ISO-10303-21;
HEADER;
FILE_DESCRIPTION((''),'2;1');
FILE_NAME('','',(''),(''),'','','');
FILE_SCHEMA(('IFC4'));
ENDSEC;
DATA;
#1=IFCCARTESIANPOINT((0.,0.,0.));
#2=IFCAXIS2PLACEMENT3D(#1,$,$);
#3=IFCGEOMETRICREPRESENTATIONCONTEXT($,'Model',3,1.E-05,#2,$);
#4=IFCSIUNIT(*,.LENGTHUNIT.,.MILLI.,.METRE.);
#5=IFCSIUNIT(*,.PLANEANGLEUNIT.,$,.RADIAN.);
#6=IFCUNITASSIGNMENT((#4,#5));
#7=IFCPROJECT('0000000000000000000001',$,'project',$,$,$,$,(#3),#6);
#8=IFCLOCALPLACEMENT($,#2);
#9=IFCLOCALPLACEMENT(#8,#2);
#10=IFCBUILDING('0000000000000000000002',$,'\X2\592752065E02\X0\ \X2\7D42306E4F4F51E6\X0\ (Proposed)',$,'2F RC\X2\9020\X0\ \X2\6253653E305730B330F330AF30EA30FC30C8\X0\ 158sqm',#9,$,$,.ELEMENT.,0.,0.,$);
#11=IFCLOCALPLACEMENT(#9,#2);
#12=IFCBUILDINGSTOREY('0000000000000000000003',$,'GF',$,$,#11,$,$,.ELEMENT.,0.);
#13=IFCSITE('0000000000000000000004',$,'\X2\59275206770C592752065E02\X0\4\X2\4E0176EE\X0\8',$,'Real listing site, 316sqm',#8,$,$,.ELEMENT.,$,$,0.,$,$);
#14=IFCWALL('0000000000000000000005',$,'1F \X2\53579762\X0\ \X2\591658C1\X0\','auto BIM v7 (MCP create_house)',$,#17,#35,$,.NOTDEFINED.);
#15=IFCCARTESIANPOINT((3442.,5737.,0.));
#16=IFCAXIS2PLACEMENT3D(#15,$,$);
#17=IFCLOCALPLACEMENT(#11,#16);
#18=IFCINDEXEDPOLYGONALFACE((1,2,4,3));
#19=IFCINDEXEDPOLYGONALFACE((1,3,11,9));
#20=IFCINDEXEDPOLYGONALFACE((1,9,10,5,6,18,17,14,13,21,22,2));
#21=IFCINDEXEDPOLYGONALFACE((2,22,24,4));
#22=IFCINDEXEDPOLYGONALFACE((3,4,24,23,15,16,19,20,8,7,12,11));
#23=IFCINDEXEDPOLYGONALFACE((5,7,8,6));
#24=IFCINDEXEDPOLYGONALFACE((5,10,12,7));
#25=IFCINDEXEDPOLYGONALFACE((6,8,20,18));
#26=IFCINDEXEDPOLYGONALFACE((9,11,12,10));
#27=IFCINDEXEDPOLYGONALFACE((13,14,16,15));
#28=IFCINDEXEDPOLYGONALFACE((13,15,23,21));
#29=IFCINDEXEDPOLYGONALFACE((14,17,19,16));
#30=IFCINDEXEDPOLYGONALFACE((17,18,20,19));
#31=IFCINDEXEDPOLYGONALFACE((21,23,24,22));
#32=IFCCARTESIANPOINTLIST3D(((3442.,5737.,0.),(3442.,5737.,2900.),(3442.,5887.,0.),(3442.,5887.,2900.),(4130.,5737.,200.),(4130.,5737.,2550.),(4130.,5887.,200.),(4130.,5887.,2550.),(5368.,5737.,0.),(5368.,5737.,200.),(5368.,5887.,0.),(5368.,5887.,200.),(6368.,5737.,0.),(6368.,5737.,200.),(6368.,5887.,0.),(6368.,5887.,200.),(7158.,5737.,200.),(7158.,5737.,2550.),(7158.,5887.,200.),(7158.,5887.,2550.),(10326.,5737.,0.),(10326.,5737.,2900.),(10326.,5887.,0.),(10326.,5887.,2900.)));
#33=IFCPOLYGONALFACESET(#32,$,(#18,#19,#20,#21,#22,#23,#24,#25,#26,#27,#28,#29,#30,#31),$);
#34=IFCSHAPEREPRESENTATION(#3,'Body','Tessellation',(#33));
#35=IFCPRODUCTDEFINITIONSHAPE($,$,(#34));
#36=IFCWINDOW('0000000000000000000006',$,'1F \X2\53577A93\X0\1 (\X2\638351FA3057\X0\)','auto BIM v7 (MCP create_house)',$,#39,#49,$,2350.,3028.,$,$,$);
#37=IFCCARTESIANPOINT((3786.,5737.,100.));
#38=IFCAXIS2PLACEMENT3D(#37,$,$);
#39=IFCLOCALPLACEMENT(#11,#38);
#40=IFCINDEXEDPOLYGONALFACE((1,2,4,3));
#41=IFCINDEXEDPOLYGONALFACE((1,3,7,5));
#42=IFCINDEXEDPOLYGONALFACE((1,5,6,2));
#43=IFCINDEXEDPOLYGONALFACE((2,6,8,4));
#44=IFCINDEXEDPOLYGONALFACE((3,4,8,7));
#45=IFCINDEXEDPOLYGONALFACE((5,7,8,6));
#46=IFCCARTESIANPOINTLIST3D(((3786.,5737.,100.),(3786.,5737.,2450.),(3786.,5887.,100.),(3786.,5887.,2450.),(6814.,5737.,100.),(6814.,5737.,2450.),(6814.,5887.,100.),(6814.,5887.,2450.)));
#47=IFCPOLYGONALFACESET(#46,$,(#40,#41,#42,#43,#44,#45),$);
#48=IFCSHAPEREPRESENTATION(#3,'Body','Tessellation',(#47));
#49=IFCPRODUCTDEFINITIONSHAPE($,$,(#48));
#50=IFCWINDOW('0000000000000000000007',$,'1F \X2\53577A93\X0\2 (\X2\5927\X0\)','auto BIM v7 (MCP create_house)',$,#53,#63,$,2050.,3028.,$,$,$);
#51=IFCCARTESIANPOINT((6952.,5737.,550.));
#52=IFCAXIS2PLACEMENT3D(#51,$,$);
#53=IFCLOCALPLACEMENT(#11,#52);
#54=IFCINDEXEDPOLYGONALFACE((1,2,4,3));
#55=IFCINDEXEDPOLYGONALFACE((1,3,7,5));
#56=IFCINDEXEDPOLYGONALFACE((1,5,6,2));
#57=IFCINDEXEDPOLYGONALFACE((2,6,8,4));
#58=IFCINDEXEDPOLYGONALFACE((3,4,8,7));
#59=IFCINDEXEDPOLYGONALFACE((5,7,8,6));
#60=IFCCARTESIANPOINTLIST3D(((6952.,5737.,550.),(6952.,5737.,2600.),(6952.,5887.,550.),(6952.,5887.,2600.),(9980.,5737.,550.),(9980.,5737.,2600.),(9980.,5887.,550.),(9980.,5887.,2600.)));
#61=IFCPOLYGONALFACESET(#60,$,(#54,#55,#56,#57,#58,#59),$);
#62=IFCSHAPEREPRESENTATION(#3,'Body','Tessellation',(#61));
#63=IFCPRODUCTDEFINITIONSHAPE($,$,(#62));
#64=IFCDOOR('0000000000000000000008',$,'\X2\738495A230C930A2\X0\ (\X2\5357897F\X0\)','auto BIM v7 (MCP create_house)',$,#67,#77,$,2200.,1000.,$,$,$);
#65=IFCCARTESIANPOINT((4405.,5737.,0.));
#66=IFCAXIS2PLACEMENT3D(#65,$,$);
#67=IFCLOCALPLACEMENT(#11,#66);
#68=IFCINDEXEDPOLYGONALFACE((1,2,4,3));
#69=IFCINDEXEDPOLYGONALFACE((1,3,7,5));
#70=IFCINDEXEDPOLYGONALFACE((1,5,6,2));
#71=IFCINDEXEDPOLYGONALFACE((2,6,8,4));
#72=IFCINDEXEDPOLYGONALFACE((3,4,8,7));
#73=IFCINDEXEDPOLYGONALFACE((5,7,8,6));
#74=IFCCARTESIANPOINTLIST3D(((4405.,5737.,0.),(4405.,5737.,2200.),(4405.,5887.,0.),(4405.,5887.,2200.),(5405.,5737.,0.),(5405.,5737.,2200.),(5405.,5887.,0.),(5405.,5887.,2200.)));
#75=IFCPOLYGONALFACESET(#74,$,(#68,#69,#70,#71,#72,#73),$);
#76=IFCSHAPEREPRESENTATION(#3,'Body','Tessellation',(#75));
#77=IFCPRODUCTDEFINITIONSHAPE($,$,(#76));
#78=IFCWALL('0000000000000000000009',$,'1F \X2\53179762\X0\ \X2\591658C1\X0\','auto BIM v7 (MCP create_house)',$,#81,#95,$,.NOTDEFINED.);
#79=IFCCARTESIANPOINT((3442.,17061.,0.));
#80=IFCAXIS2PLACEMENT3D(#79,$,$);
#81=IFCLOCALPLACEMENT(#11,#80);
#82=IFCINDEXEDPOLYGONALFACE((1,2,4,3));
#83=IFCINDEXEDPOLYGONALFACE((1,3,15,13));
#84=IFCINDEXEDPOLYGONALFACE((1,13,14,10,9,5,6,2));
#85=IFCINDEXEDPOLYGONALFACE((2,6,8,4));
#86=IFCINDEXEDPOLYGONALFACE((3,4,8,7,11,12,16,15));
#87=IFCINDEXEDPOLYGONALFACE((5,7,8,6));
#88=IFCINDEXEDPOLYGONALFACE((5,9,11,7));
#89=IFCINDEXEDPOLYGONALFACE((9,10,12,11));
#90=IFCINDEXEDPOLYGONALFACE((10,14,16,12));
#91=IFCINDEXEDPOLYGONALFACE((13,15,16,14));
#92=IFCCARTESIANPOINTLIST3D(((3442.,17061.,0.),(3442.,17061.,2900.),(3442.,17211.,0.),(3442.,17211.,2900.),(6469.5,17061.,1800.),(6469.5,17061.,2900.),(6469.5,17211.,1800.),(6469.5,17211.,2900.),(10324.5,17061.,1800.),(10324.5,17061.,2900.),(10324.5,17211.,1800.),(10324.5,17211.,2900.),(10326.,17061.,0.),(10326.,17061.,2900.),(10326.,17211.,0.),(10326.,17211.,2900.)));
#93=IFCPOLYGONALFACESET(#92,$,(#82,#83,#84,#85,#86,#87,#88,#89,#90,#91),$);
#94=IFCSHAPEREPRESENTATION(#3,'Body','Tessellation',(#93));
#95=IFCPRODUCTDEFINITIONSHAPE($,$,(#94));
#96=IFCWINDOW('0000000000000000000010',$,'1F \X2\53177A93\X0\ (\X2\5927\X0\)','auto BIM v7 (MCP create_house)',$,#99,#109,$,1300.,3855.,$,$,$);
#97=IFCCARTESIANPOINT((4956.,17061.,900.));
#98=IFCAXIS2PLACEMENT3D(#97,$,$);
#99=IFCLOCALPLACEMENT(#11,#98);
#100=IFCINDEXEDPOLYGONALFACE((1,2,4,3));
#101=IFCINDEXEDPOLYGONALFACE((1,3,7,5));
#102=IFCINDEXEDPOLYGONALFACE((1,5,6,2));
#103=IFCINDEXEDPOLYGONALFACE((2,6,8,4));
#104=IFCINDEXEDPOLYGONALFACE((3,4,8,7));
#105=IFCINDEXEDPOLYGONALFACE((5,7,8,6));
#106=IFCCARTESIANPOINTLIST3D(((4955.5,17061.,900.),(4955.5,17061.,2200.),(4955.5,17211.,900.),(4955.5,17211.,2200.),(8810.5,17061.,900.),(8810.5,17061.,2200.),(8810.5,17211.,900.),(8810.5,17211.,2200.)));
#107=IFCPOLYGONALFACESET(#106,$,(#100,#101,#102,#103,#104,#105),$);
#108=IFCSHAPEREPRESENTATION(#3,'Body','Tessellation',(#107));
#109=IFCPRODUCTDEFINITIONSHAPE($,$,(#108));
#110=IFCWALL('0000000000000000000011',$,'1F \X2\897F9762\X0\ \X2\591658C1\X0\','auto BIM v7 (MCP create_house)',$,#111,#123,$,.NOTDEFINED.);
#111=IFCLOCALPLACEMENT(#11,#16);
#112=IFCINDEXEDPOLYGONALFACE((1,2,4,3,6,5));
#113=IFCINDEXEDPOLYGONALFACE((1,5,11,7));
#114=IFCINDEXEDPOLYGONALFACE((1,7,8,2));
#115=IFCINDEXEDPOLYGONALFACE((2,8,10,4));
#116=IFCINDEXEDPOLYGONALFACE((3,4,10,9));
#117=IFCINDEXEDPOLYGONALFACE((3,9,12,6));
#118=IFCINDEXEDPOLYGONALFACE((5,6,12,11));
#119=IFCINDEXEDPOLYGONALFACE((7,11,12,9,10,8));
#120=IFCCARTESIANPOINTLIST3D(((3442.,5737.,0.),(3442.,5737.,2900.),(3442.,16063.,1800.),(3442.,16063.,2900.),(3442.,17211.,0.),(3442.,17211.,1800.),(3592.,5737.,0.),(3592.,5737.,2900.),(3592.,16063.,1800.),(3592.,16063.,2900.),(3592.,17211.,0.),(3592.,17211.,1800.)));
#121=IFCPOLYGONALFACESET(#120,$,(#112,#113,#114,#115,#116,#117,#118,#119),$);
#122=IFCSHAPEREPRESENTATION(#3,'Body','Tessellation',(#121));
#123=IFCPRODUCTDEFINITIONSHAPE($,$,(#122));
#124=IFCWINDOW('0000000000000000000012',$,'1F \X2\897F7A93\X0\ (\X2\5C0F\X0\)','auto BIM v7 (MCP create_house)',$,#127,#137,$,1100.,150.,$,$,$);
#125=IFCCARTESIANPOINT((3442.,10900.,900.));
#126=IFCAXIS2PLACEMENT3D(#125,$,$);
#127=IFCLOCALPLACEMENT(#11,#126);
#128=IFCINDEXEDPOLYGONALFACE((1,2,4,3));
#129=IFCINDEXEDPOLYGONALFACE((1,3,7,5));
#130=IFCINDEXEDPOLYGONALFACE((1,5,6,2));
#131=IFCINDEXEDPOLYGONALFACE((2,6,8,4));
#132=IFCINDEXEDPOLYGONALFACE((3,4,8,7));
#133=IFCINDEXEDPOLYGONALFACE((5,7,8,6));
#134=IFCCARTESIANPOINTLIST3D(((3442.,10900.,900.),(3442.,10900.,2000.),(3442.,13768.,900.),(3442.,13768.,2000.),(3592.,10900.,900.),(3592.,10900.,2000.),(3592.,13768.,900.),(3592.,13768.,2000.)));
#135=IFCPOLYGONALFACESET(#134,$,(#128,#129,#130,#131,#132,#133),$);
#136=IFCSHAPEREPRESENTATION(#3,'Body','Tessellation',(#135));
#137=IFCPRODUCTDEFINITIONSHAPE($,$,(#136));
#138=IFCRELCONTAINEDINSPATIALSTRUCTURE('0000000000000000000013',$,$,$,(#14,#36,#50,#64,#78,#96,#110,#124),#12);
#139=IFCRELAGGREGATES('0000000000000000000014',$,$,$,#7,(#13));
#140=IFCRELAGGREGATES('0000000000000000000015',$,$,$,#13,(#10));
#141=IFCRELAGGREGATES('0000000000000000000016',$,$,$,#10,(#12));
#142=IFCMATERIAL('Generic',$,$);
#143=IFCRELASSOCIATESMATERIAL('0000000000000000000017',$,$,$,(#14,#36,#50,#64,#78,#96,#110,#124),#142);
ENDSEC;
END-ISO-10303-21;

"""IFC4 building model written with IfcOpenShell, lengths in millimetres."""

from ifc_helpers import new_model, si_unit, frame, frame_2d, origin, place, context, project, spatial, rectangle, extrude, material, element, fill, save


model = new_model("IFC4")

# Units and contexts
model_context = context("Model", 3, precision=1e-05, world=origin())
ifc_project = project(units=[si_unit("LENGTHUNIT", "METRE", prefix="MILLI"), si_unit("PLANEANGLEUNIT", "RADIAN")], contexts=[model_context])

# Site, building, storey
site_placement = place(None, origin())
site = spatial("IfcSite", under=ifc_project, at=site_placement, Name="大分県大分市4丁目8", ObjectType="Real listing site, 316sqm", CompositionType="ELEMENT", RefElevation=0.0)
building_placement = place(site_placement, origin())
building = spatial("IfcBuilding", under=site, at=building_placement, Name="大分市 終の住処 (Proposed)", ObjectType="2F RC造 打放しコンクリート 158sqm", CompositionType="ELEMENT", ElevationOfRefHeight=0.0, ElevationOfTerrain=0.0)
storey_placement = place(building_placement, origin())
storey = spatial("IfcBuildingStorey", under=building, at=storey_placement, Name="GF", CompositionType="ELEMENT", Elevation=0.0)

# Shared definitions
ifc_material = material(Name="Generic")

# Wall, openings, windows, door
wall_1_placement = place(storey_placement, frame((3442.0, 5737.0, 0.0)))
wall_1 = element("IfcWall", 1, at=wall_1_placement, inside=storey, material=ifc_material, Name="1F 南面 外壁", Description="auto BIM v7 (MCP create_house)", PredefinedType="NOTDEFINED", context=model_context, shape_type="SweptSolid", body=[
    extrude(rectangle(XDim=6884.0, YDim=150.0, at=frame_2d((3442.0, 75.0))), frame((3442.0, 5737.0, 0.0)), (0.0, 0.0, 1.0), 2900.0),
])
opening_1_placement = place(storey_placement, frame((3786.0, 5737.0, 100.0)))
opening_1 = element("IfcOpeningElement", 2, at=opening_1_placement, cuts=wall_1, PredefinedType="NOTDEFINED", context=model_context, shape_type="SweptSolid", body=[
    extrude(rectangle(XDim=3028.0, YDim=150.0, at=frame_2d((1514.0, 75.0))), frame((3786.0, 5737.0, 100.0)), (0.0, 0.0, 1.0), 2350.0),
])
opening_2_placement = place(storey_placement, frame((6952.0, 5737.0, 550.0)))
opening_2 = element("IfcOpeningElement", 3, at=opening_2_placement, cuts=wall_1, PredefinedType="NOTDEFINED", context=model_context, shape_type="SweptSolid", body=[
    extrude(rectangle(XDim=3028.0, YDim=150.0, at=frame_2d((1514.0, 75.0))), frame((6952.0, 5737.0, 550.0)), (0.0, 0.0, 1.0), 2050.0),
])
opening_3_placement = place(storey_placement, frame((4405.0, 5737.0, 0.0)))
opening_3 = element("IfcOpeningElement", 4, at=opening_3_placement, cuts=wall_1, PredefinedType="NOTDEFINED", context=model_context, shape_type="SweptSolid", body=[
    extrude(rectangle(XDim=1000.0, YDim=150.0, at=frame_2d((500.0, 75.0))), frame((4405.0, 5737.0, 0.0)), (0.0, 0.0, 1.0), 2200.0),
])
window_1_placement = place(storey_placement, frame((3786.0, 5737.0, 100.0)))
window_1 = element("IfcWindow", 5, at=window_1_placement, inside=storey, material=ifc_material, Name="1F 南窓1 (掃出し)", Description="auto BIM v7 (MCP create_house)", OverallHeight=2350.0, OverallWidth=3028.0, context=model_context, shape_type="SweptSolid", body=[
    extrude(rectangle(XDim=3028.0, YDim=150.0, at=frame_2d((1514.0, 75.0))), frame((3786.0, 5737.0, 100.0)), (0.0, 0.0, 1.0), 2350.0),
])
fill(opening_1, window_1)
window_2_placement = place(storey_placement, frame((6952.0, 5737.0, 550.0)))
window_2 = element("IfcWindow", 6, at=window_2_placement, inside=storey, material=ifc_material, Name="1F 南窓2 (大)", Description="auto BIM v7 (MCP create_house)", OverallHeight=2050.0, OverallWidth=3028.0, context=model_context, shape_type="SweptSolid", body=[
    extrude(rectangle(XDim=3028.0, YDim=150.0, at=frame_2d((1514.0, 75.0))), frame((6952.0, 5737.0, 550.0)), (0.0, 0.0, 1.0), 2050.0),
])
fill(opening_2, window_2)
door_placement = place(storey_placement, frame((4405.0, 5737.0, 0.0)))
door = element("IfcDoor", 7, at=door_placement, inside=storey, material=ifc_material, Name="玄関ドア (南西)", Description="auto BIM v7 (MCP create_house)", OverallHeight=2200.0, OverallWidth=1000.0, context=model_context, shape_type="SweptSolid", body=[
    extrude(rectangle(XDim=1000.0, YDim=150.0, at=frame_2d((500.0, 75.0))), frame((4405.0, 5737.0, 0.0)), (0.0, 0.0, 1.0), 2200.0),
])
fill(opening_3, door)

# Walls, openings, windows
wall_2_placement = place(storey_placement, frame((3442.0, 17061.0, 0.0)))
wall_2 = element("IfcWall", 8, at=wall_2_placement, inside=storey, material=ifc_material, Name="1F 北面 外壁", Description="auto BIM v7 (MCP create_house)", PredefinedType="NOTDEFINED", context=model_context, shape_type="SweptSolid", body=[
    extrude(rectangle(XDim=6884.0, YDim=150.0, at=frame_2d((3442.0, 75.0))), frame((3442.0, 17061.0, 0.0)), (0.0, 0.0, 1.0), 2900.0),
])
opening_4_placement = place(storey_placement, frame((4956.0, 17061.0, 900.0)))
opening_4 = element("IfcOpeningElement", 9, at=opening_4_placement, cuts=wall_2, PredefinedType="NOTDEFINED", context=model_context, shape_type="SweptSolid", body=[
    extrude(rectangle(XDim=3855.0, YDim=150.0, at=frame_2d((1927.0, 75.0))), frame((4956.0, 17061.0, 900.0)), (0.0, 0.0, 1.0), 1300.0),
])
window_3_placement = place(storey_placement, frame((4956.0, 17061.0, 900.0)))
window_3 = element("IfcWindow", 10, at=window_3_placement, inside=storey, material=ifc_material, Name="1F 北窓 (大)", Description="auto BIM v7 (MCP create_house)", OverallHeight=1300.0, OverallWidth=3855.0, context=model_context, shape_type="SweptSolid", body=[
    extrude(rectangle(XDim=3855.0, YDim=150.0, at=frame_2d((1927.0, 75.0))), frame((4956.0, 17061.0, 900.0)), (0.0, 0.0, 1.0), 1300.0),
])
fill(opening_4, window_3)
wall_3_placement = place(storey_placement, frame((3442.0, 5737.0, 0.0)))
wall_3 = element("IfcWall", 11, at=wall_3_placement, inside=storey, material=ifc_material, Name="1F 西面 外壁", Description="auto BIM v7 (MCP create_house)", PredefinedType="NOTDEFINED", context=model_context, shape_type="SweptSolid", body=[
    extrude(rectangle(XDim=150.0, YDim=11474.0, at=frame_2d((75.0, 5737.0))), frame((3442.0, 5737.0, 0.0)), (0.0, 0.0, 1.0), 2900.0),
])
opening_5_placement = place(storey_placement, frame((3442.0, 10900.0, 900.0)))
opening_5 = element("IfcOpeningElement", 12, at=opening_5_placement, cuts=wall_3, PredefinedType="NOTDEFINED", context=model_context, shape_type="SweptSolid", body=[
    extrude(rectangle(XDim=150.0, YDim=2868.0, at=frame_2d((75.0, 1434.0))), frame((3442.0, 10900.0, 900.0)), (0.0, 0.0, 1.0), 1100.0),
])
window_4_placement = place(storey_placement, frame((3442.0, 10900.0, 900.0)))
window_4 = element("IfcWindow", 13, at=window_4_placement, inside=storey, material=ifc_material, Name="1F 西窓 (小)", Description="auto BIM v7 (MCP create_house)", OverallHeight=1100.0, OverallWidth=150.0, context=model_context, shape_type="SweptSolid", body=[
    extrude(rectangle(XDim=150.0, YDim=2868.0, at=frame_2d((75.0, 1434.0))), frame((3442.0, 10900.0, 900.0)), (0.0, 0.0, 1.0), 1100.0),
])
fill(opening_5, window_4)

save(model, "model.ifc")
